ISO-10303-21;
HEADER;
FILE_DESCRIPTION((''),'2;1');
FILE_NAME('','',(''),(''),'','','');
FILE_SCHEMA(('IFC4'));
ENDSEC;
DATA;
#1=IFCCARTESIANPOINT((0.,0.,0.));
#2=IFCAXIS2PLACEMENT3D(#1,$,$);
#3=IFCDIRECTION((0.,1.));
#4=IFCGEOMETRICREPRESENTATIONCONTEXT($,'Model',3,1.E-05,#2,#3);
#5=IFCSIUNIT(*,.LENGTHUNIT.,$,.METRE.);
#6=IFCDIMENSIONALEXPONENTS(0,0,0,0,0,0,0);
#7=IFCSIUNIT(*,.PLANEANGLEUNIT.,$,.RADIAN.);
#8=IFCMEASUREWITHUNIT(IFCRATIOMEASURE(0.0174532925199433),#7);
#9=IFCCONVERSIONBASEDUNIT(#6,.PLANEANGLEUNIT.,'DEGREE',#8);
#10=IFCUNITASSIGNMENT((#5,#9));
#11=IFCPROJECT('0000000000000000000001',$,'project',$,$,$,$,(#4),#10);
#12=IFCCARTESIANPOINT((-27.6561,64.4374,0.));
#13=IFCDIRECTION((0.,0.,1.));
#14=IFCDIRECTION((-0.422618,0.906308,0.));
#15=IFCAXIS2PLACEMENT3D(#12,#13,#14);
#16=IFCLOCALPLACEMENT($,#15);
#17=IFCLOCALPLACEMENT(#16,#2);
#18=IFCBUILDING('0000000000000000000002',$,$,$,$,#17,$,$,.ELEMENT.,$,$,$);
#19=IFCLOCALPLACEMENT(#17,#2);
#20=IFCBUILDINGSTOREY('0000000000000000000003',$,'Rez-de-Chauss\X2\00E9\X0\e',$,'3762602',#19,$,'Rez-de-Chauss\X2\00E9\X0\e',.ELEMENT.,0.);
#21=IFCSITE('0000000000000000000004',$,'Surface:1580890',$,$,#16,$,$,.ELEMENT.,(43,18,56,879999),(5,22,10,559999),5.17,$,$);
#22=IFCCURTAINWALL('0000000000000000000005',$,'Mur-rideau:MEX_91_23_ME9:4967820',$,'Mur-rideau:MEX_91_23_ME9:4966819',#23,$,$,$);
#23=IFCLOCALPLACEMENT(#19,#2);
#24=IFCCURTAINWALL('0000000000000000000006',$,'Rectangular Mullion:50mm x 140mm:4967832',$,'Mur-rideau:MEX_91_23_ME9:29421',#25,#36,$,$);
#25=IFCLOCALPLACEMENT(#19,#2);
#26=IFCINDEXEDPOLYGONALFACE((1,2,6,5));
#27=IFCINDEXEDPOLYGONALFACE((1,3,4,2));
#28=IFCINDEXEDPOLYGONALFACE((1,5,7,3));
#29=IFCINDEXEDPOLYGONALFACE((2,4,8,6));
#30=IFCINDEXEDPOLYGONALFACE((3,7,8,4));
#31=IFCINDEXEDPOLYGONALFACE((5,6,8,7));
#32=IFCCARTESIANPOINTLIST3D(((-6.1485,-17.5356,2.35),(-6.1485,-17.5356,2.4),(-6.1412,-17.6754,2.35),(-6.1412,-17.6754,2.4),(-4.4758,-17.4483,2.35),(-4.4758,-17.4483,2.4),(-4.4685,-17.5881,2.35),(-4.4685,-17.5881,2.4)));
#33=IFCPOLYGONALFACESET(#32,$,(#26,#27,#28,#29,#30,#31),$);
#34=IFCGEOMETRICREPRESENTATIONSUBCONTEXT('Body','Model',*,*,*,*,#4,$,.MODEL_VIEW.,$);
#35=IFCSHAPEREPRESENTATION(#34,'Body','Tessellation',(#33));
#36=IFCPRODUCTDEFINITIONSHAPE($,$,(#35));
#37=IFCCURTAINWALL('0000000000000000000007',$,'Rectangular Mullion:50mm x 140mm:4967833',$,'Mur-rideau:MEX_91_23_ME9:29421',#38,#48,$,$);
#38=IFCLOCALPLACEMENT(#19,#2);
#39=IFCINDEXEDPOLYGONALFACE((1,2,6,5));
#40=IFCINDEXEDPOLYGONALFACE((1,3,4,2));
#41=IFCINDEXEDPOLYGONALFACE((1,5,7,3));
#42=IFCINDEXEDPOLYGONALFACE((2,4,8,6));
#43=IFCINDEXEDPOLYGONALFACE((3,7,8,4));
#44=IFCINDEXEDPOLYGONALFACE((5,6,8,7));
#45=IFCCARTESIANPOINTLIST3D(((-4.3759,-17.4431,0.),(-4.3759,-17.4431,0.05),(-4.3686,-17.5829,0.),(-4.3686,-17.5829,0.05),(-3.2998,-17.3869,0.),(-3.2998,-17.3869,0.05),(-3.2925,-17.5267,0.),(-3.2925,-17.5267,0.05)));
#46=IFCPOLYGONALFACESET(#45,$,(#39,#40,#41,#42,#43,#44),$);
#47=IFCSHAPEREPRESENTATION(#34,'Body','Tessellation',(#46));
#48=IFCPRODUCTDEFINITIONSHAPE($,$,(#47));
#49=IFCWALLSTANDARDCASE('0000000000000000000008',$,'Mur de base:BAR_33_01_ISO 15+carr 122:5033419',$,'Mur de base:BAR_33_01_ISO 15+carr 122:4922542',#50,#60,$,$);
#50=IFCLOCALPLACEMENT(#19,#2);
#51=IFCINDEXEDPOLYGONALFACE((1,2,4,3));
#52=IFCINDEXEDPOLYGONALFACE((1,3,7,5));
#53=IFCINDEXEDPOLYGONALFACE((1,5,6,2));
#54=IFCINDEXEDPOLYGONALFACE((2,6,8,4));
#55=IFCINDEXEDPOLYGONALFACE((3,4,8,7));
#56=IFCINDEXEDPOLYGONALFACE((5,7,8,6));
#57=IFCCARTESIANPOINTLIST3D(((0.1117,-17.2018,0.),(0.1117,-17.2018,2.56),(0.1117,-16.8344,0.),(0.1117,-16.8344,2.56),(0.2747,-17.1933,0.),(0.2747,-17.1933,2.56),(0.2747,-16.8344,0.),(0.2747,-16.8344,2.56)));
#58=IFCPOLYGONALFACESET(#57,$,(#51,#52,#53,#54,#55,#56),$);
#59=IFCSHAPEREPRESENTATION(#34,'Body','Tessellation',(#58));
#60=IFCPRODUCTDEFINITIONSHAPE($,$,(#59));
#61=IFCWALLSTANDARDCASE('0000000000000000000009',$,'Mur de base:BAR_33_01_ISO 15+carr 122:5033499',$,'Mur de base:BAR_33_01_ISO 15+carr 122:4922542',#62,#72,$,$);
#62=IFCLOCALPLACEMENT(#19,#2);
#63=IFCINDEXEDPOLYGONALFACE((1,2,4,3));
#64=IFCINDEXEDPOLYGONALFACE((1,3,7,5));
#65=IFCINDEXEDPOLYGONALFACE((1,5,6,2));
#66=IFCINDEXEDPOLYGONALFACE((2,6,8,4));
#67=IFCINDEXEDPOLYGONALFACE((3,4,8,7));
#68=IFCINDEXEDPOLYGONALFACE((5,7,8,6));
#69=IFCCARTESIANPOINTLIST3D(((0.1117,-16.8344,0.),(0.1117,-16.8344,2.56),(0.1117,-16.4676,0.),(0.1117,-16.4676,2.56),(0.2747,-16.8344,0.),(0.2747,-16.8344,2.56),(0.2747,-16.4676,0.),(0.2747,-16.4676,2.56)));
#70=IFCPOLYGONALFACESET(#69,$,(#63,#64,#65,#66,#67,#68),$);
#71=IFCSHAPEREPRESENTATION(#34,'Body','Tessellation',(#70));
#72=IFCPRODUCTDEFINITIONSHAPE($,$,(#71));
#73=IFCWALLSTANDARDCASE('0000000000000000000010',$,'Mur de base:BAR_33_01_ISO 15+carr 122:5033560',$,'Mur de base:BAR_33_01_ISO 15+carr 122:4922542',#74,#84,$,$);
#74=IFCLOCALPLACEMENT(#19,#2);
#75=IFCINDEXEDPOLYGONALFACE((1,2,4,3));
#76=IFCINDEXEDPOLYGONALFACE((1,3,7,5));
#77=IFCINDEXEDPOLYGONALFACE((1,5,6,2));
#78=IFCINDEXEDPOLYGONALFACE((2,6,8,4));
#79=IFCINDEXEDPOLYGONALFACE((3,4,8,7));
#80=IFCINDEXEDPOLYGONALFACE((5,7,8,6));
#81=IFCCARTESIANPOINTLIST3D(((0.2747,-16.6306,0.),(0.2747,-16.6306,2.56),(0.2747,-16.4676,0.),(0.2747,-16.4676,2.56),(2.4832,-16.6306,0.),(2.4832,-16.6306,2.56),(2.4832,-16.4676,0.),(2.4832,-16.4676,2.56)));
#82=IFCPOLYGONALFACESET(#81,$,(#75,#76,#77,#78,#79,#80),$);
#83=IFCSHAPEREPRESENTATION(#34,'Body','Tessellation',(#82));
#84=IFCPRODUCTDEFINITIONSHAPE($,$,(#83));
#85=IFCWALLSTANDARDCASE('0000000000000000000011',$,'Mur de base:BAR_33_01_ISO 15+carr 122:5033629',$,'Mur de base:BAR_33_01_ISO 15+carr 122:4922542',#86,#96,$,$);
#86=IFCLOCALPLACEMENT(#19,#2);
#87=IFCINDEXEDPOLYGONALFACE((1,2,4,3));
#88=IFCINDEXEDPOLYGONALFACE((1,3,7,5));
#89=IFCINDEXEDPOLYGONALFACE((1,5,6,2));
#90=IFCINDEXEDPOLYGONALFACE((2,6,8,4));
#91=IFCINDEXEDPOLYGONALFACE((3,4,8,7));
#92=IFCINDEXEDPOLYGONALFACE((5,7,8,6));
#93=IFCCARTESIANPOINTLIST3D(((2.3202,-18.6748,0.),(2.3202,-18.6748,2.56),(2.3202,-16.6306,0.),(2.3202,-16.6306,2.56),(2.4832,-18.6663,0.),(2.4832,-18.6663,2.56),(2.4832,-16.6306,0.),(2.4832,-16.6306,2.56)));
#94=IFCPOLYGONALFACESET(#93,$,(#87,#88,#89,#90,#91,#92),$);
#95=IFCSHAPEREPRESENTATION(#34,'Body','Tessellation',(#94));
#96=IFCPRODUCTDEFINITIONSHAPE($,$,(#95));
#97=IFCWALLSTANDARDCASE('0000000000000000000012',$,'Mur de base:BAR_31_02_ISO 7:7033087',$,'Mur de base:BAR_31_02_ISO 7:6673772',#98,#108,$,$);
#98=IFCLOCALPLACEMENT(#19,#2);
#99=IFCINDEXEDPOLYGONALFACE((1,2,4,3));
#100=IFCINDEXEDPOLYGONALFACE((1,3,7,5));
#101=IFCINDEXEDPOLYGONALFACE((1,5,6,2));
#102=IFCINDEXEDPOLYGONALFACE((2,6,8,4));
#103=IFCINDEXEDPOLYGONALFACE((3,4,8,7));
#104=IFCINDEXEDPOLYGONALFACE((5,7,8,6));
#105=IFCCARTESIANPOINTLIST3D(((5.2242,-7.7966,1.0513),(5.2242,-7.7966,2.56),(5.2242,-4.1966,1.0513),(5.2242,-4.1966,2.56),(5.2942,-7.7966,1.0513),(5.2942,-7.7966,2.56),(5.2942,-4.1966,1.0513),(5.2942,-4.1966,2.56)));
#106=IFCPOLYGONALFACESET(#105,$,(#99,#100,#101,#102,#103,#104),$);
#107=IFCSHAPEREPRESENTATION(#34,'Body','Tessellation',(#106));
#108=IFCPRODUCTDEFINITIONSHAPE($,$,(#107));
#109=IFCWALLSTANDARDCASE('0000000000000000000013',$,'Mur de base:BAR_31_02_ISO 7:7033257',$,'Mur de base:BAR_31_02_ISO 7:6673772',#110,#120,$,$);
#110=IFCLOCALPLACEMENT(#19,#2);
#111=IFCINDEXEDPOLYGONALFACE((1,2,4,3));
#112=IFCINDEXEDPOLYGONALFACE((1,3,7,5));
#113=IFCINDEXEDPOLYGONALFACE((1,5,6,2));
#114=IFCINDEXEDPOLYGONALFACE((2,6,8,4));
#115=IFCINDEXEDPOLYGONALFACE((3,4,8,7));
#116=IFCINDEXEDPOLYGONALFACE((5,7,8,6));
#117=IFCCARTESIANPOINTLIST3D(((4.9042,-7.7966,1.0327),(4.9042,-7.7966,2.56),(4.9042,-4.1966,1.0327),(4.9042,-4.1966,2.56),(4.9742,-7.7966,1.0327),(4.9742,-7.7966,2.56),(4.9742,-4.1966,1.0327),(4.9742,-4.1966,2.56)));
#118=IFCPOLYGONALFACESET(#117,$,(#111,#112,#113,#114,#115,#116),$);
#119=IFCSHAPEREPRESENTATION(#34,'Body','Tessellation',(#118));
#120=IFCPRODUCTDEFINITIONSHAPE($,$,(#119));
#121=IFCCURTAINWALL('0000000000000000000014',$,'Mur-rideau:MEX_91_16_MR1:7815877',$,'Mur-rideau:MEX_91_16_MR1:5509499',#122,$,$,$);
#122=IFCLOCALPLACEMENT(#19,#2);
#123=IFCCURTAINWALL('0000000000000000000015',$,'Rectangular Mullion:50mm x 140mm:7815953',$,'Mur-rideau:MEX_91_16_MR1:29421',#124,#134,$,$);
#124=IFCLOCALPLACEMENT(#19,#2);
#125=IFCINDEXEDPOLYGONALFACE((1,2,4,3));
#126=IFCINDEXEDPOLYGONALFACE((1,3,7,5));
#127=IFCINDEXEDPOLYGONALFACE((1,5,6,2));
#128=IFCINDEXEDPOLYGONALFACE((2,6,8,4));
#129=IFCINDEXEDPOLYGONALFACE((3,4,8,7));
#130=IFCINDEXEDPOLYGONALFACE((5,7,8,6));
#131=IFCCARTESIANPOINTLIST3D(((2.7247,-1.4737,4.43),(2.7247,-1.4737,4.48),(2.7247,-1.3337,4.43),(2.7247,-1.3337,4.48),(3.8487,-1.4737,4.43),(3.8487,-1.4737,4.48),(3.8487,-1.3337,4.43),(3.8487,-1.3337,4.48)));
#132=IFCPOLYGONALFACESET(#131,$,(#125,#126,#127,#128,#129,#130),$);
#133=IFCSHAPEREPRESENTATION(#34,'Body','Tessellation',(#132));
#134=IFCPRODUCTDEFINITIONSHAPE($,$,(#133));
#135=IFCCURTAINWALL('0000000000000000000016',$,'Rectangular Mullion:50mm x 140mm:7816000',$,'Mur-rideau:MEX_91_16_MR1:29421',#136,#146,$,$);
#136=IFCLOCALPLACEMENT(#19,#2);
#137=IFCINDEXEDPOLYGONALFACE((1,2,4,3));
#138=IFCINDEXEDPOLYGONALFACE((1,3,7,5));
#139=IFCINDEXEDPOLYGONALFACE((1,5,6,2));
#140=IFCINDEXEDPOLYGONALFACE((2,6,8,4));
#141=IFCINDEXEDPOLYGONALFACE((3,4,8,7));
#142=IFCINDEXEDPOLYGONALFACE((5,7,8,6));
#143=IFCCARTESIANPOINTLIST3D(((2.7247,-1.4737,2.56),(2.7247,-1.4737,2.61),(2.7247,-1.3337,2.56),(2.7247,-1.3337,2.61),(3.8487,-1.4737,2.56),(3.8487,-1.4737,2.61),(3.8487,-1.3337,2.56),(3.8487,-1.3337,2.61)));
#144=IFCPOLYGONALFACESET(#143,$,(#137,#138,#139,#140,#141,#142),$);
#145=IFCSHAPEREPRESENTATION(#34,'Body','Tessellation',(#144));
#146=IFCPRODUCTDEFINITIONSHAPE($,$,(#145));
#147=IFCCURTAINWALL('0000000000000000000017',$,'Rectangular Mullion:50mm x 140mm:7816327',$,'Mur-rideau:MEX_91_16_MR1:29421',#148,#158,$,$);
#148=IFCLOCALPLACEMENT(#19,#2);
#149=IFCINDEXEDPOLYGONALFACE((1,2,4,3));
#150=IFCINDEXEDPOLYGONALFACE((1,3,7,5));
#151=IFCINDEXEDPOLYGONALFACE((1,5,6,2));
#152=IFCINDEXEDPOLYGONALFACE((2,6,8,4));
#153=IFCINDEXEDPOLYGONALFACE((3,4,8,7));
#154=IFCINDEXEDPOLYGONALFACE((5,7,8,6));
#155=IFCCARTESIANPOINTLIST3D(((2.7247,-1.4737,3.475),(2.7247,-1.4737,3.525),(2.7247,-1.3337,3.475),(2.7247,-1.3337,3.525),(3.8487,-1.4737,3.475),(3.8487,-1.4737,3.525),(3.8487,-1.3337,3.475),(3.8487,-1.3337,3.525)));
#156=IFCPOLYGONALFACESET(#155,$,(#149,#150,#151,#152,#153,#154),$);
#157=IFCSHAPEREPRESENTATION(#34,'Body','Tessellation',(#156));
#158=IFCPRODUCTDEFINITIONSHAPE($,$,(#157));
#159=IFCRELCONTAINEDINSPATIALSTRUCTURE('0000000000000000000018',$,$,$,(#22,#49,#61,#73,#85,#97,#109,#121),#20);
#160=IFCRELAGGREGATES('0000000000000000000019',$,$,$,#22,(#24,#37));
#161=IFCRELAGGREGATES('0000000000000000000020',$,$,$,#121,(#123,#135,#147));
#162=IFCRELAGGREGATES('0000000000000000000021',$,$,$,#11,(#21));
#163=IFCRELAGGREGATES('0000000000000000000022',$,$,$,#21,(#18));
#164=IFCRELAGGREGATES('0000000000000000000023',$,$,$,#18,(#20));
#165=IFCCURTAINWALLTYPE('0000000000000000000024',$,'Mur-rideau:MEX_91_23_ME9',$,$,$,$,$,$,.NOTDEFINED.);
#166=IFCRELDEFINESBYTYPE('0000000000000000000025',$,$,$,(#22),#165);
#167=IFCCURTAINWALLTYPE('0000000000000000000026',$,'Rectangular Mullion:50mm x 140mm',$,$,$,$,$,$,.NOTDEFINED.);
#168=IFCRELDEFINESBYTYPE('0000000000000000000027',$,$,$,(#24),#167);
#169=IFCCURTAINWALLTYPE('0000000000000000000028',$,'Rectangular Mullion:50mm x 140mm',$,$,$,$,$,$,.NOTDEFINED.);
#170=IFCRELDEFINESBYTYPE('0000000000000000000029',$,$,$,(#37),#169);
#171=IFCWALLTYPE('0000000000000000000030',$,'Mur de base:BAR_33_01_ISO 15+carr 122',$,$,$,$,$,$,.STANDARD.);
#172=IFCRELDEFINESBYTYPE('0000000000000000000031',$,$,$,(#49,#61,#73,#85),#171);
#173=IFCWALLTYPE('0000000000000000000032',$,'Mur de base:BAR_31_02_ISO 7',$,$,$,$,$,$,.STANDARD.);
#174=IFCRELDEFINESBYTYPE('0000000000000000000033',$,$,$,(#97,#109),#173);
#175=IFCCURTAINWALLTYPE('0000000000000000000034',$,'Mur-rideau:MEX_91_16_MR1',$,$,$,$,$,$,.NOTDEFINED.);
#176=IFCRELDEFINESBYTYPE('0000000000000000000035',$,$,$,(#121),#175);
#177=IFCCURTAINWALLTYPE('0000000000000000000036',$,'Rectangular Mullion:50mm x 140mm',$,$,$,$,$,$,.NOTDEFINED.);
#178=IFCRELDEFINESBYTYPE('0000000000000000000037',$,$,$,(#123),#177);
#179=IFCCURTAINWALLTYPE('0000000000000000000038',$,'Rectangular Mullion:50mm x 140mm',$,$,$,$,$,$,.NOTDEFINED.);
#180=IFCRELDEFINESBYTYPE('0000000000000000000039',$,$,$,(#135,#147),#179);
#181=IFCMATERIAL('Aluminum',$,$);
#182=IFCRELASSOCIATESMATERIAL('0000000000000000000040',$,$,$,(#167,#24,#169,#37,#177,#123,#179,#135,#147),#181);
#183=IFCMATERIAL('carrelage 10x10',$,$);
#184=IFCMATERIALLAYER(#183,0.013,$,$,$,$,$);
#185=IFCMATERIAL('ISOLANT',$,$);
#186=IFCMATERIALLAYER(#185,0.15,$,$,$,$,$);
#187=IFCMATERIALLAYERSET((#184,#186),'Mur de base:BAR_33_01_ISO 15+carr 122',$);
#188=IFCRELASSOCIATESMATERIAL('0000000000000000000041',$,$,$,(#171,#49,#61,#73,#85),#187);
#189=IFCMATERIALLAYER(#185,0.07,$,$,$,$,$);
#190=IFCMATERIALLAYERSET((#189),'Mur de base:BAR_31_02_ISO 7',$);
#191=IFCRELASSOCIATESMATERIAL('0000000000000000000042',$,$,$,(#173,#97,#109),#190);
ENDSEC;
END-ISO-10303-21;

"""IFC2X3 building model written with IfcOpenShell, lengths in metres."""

from ifc_helpers import new_model, entity, si_unit, converted_unit, direction, frame, frame_2d, origin, origin_2d_with_axis, place, context, subcontext, project, spatial, polyline, rectangle, outline, extrude, clip, halfspace, source, transform, mapped, material, layer, layer_set, layer_usage, type_object, type_shapes, element, aggregate, save


model = new_model("IFC2X3")

# Units and contexts
model_context = context("Model", 3, precision=1e-05, world=origin(), true_north=direction((0.0, 1.0)))
body_context = subcontext(model_context, "Body", "Model", "MODEL_VIEW")
ifc_project = project(units=[si_unit("LENGTHUNIT", "METRE"), converted_unit("PLANEANGLEUNIT", "DEGREE", entity("IfcRatioMeasure", 0.0174532925199433), si_unit("PLANEANGLEUNIT", "RADIAN"), dimensions=[0, 0, 0, 0, 0, 0, 0])], contexts=[model_context])

# Site, building, storey
site_placement = place(None, frame((-27.6561, 64.4374, 0.0), z_axis=(0.0, 0.0, 1.0), x_axis=(-0.422618, 0.906308, 0.0)))
site = spatial("IfcSite", under=ifc_project, at=site_placement, Name="Surface:1580890", CompositionType="ELEMENT", RefLatitude=(43, 18, 56, 879999), RefLongitude=(5, 22, 10, 559999), RefElevation=5.17)
building_placement = place(site_placement, origin())
building = spatial("IfcBuilding", under=site, at=building_placement, CompositionType="ELEMENT")
storey_placement = place(building_placement, origin())
storey = spatial("IfcBuildingStorey", under=building, at=storey_placement, Name="Rez-de-Chaussée", ObjectType="3762602", LongName="Rez-de-Chaussée", CompositionType="ELEMENT", Elevation=0.0)

# Shared definitions
ifc_material_1 = material(Name="ISOLANT")

# Curtain walls
curtain_wall_type_1 = type_object("IfcCurtainWallType", Name="Mur-rideau:MEX_91_23_ME9", PredefinedType="NOTDEFINED")
curtain_wall_1_placement = place(storey_placement, origin())
curtain_wall_1 = element("IfcCurtainWall", 1, at=curtain_wall_1_placement, inside=storey, type_object=curtain_wall_type_1, Name="Mur-rideau:MEX_91_23_ME9:4967820", ObjectType="Mur-rideau:MEX_91_23_ME9:4966819")
ifc_material_2 = material(Name="Aluminum")
curtain_wall_type_2 = type_object("IfcCurtainWallType", Name="Rectangular Mullion:50mm x 140mm", PredefinedType="NOTDEFINED", material=ifc_material_2)
shared_shape_1 = source(origin(), body_context, "Body", "SweptSolid", [
    extrude(rectangle(XDim=0.05, YDim=0.14, at=origin_2d_with_axis()), frame((-0.025, 0.0, -1.675), z_axis=(0.0, 0.0, 1.0), x_axis=(-1.0, 0.0, 0.0)), (0.0, 0.0, 1.0), 1.675),
])
type_shapes(curtain_wall_type_2, [shared_shape_1])
curtain_wall_2_placement = place(storey_placement, frame((-4.4722, -17.5182, 2.4), z_axis=(0.998641, 0.052122, 0.0), x_axis=(0.0, 0.0, 1.0)))
curtain_wall_2 = element("IfcCurtainWall", 2, at=curtain_wall_2_placement, type_object=curtain_wall_type_2, material=ifc_material_2, Name="Rectangular Mullion:50mm x 140mm:4967832", ObjectType="Mur-rideau:MEX_91_23_ME9:29421", context=body_context, shape_type="MappedRepresentation", body=[
    mapped(shared_shape_1, transform((0.0, 0.0, 0.0), scale=1.0)),
])
curtain_wall_type_3 = type_object("IfcCurtainWallType", Name="Rectangular Mullion:50mm x 140mm", PredefinedType="NOTDEFINED", material=ifc_material_2)
shared_shape_2 = source(origin(), body_context, "Body", "SweptSolid", [
    extrude(rectangle(XDim=0.05, YDim=0.14, at=origin_2d_with_axis()), frame((-0.025, 0.0, -1.0776), z_axis=(0.0, 0.0, 1.0), x_axis=(-1.0, 0.0, 0.0)), (0.0, 0.0, 1.0), 1.0776),
])
type_shapes(curtain_wall_type_3, [shared_shape_2])
curtain_wall_3_placement = place(storey_placement, frame((-4.3723, -17.513, 0.0), z_axis=(-0.998641, -0.052122, 0.0), x_axis=(0.0, 0.0, -1.0)))
curtain_wall_3 = element("IfcCurtainWall", 3, at=curtain_wall_3_placement, type_object=curtain_wall_type_3, material=ifc_material_2, Name="Rectangular Mullion:50mm x 140mm:4967833", ObjectType="Mur-rideau:MEX_91_23_ME9:29421", context=body_context, shape_type="MappedRepresentation", body=[
    mapped(shared_shape_2, transform((0.0, 0.0, 0.0), scale=1.0)),
])
aggregate(curtain_wall_1, [curtain_wall_2, curtain_wall_3])

# Walls
ifc_material_3 = material(Name="carrelage 10x10")
ifc_layer_1 = layer(ifc_material_3, 0.013)
ifc_layer_2 = layer(ifc_material_1, 0.15)
ifc_layer_set_1 = layer_set([ifc_layer_1, ifc_layer_2], Name="Mur de base:BAR_33_01_ISO 15+carr 122")
ifc_layer_usage_1 = layer_usage(ifc_layer_set_1, "AXIS2", "NEGATIVE", 0.0815)
wall_type_1 = type_object("IfcWallType", Name="Mur de base:BAR_33_01_ISO 15+carr 122", PredefinedType="STANDARD", material=ifc_layer_set_1)
wall_1_placement = place(storey_placement, frame((0.1932, -17.2018, 0.0), z_axis=(0.0, 0.0, 1.0), x_axis=(0.0, 1.0, 0.0)))
element("IfcWallStandardCase", 4, at=wall_1_placement, inside=storey, type_object=wall_type_1, material=ifc_layer_usage_1, Name="Mur de base:BAR_33_01_ISO 15+carr 122:5033419", ObjectType="Mur de base:BAR_33_01_ISO 15+carr 122:4922542", context=body_context, shape_type="Clipping", body=[
    clip(extrude(outline(polyline([(0.3674, -0.0815), (0.3674, 0.0815), (0.0, 0.0815), (0.0085, -0.0815), (0.3674, -0.0815)])), origin(), (0.0, 0.0, 1.0), 2.56), halfspace(origin(), True)),
])
ifc_layer_usage_2 = layer_usage(ifc_layer_set_1, "AXIS2", "NEGATIVE", 0.0815)
wall_2_placement = place(storey_placement, frame((0.1932, -16.8344, 0.0), z_axis=(0.0, 0.0, 1.0), x_axis=(0.0, 1.0, 0.0)))
element("IfcWallStandardCase", 5, at=wall_2_placement, inside=storey, type_object=wall_type_1, material=ifc_layer_usage_2, Name="Mur de base:BAR_33_01_ISO 15+carr 122:5033499", ObjectType="Mur de base:BAR_33_01_ISO 15+carr 122:4922542", context=body_context, shape_type="Clipping", body=[
    clip(extrude(rectangle(XDim=0.3669, YDim=0.163, at=frame_2d((0.1834, 0.0), x_axis=(-1.0, 0.0))), origin(), (0.0, 0.0, 1.0), 2.56), halfspace(origin(), True)),
])
ifc_layer_usage_3 = layer_usage(ifc_layer_set_1, "AXIS2", "NEGATIVE", 0.0815)
wall_3_placement = place(storey_placement, frame((0.2747, -16.5491, 0.0)))
element("IfcWallStandardCase", 6, at=wall_3_placement, inside=storey, type_object=wall_type_1, material=ifc_layer_usage_3, Name="Mur de base:BAR_33_01_ISO 15+carr 122:5033560", ObjectType="Mur de base:BAR_33_01_ISO 15+carr 122:4922542", context=body_context, shape_type="Clipping", body=[
    clip(extrude(rectangle(XDim=2.2084, YDim=0.163, at=frame_2d((1.1042, 0.0), x_axis=(-1.0, 0.0))), origin(), (0.0, 0.0, 1.0), 2.56), halfspace(origin(), True)),
])
ifc_layer_usage_4 = layer_usage(ifc_layer_set_1, "AXIS2", "NEGATIVE", 0.0815)
wall_4_placement = place(storey_placement, frame((2.4017, -16.6306, 0.0), z_axis=(0.0, 0.0, 1.0), x_axis=(0.0, -1.0, 0.0)))
element("IfcWallStandardCase", 7, at=wall_4_placement, inside=storey, type_object=wall_type_1, material=ifc_layer_usage_4, Name="Mur de base:BAR_33_01_ISO 15+carr 122:5033629", ObjectType="Mur de base:BAR_33_01_ISO 15+carr 122:4922542", context=body_context, shape_type="Clipping", body=[
    clip(extrude(outline(polyline([(2.0442, -0.0815), (2.0357, 0.0815), (1.8725, 0.0815), (0.0, 0.0815), (0.0, -0.0815), (2.0442, -0.0815)])), origin(), (0.0, 0.0, 1.0), 2.56), halfspace(origin(), True)),
])
ifc_layer_3 = layer(ifc_material_1, 0.07)
ifc_layer_set_2 = layer_set([ifc_layer_3], Name="Mur de base:BAR_31_02_ISO 7")
ifc_layer_usage_5 = layer_usage(ifc_layer_set_2, "AXIS2", "NEGATIVE", 0.035)
wall_type_2 = type_object("IfcWallType", Name="Mur de base:BAR_31_02_ISO 7", PredefinedType="STANDARD", material=ifc_layer_set_2)
wall_5_placement = place(storey_placement, frame((5.2592, -4.1966, 1.0513), z_axis=(0.0, 0.0, 1.0), x_axis=(0.0, -1.0, 0.0)))
element("IfcWallStandardCase", 8, at=wall_5_placement, inside=storey, type_object=wall_type_2, material=ifc_layer_usage_5, Name="Mur de base:BAR_31_02_ISO 7:7033087", ObjectType="Mur de base:BAR_31_02_ISO 7:6673772", context=body_context, shape_type="Clipping", body=[
    clip(extrude(rectangle(XDim=3.6, YDim=0.07, at=frame_2d((1.8, 0.0), x_axis=(-1.0, 0.0))), origin(), (0.0, 0.0, 1.0), 1.5087), halfspace(origin(), True)),
])
ifc_layer_usage_6 = layer_usage(ifc_layer_set_2, "AXIS2", "POSITIVE", -0.035)
wall_6_placement = place(storey_placement, frame((4.9392, -4.1966, 1.0327), z_axis=(0.0, 0.0, 1.0), x_axis=(0.0, -1.0, 0.0)))
element("IfcWallStandardCase", 9, at=wall_6_placement, inside=storey, type_object=wall_type_2, material=ifc_layer_usage_6, Name="Mur de base:BAR_31_02_ISO 7:7033257", ObjectType="Mur de base:BAR_31_02_ISO 7:6673772", context=body_context, shape_type="Clipping", body=[
    clip(extrude(rectangle(XDim=3.6, YDim=0.07, at=frame_2d((1.8, 0.0), x_axis=(-1.0, 0.0))), origin(), (0.0, 0.0, 1.0), 1.5273), halfspace(origin(), True)),
])

# Curtain walls
curtain_wall_type_4 = type_object("IfcCurtainWallType", Name="Mur-rideau:MEX_91_16_MR1", PredefinedType="NOTDEFINED")
curtain_wall_4_placement = place(storey_placement, origin())
curtain_wall_4 = element("IfcCurtainWall", 10, at=curtain_wall_4_placement, inside=storey, type_object=curtain_wall_type_4, Name="Mur-rideau:MEX_91_16_MR1:7815877", ObjectType="Mur-rideau:MEX_91_16_MR1:5509499")
curtain_wall_type_5 = type_object("IfcCurtainWallType", Name="Rectangular Mullion:50mm x 140mm", PredefinedType="NOTDEFINED", material=ifc_material_2)
shared_shape_3 = source(origin(), body_context, "Body", "SweptSolid", [
    extrude(rectangle(XDim=0.05, YDim=0.14, at=origin_2d_with_axis()), frame((-0.025, 0.0, -1.124), z_axis=(0.0, 0.0, 1.0), x_axis=(-1.0, 0.0, 0.0)), (0.0, 0.0, 1.0), 1.124),
])
type_shapes(curtain_wall_type_5, [shared_shape_3])
curtain_wall_5_placement = place(storey_placement, frame((2.7247, -1.4037, 4.48), z_axis=(-1.0, 0.0, 0.0), x_axis=(0.0, 0.0, 1.0)))
curtain_wall_5 = element("IfcCurtainWall", 11, at=curtain_wall_5_placement, type_object=curtain_wall_type_5, material=ifc_material_2, Name="Rectangular Mullion:50mm x 140mm:7815953", ObjectType="Mur-rideau:MEX_91_16_MR1:29421", context=body_context, shape_type="MappedRepresentation", body=[
    mapped(shared_shape_3, transform((0.0, 0.0, 0.0), scale=1.0)),
])
curtain_wall_type_6 = type_object("IfcCurtainWallType", Name="Rectangular Mullion:50mm x 140mm", PredefinedType="NOTDEFINED", material=ifc_material_2)
shared_shape_4 = source(origin(), body_context, "Body", "SweptSolid", [
    extrude(rectangle(XDim=0.05, YDim=0.14, at=origin_2d_with_axis()), frame((0.0, 0.0, -1.124), z_axis=(0.0, 0.0, 1.0), x_axis=(-1.0, 0.0, 0.0)), (0.0, 0.0, 1.0), 1.124),
])
type_shapes(curtain_wall_type_6, [shared_shape_4])
curtain_wall_6_placement = place(storey_placement, frame((2.7247, -1.4037, 2.585), z_axis=(-1.0, 0.0, 0.0), x_axis=(0.0, 0.0, 1.0)))
curtain_wall_6 = element("IfcCurtainWall", 12, at=curtain_wall_6_placement, type_object=curtain_wall_type_6, material=ifc_material_2, Name="Rectangular Mullion:50mm x 140mm:7816000", ObjectType="Mur-rideau:MEX_91_16_MR1:29421", context=body_context, shape_type="MappedRepresentation", body=[
    mapped(shared_shape_4, transform((0.0, 0.0, 0.0), scale=1.0)),
])
curtain_wall_7_placement = place(storey_placement, frame((2.7247, -1.4037, 3.5), z_axis=(-1.0, 0.0, 0.0), x_axis=(0.0, 0.0, 1.0)))
curtain_wall_7 = element("IfcCurtainWall", 13, at=curtain_wall_7_placement, type_object=curtain_wall_type_6, material=ifc_material_2, Name="Rectangular Mullion:50mm x 140mm:7816327", ObjectType="Mur-rideau:MEX_91_16_MR1:29421", context=body_context, shape_type="MappedRepresentation", body=[
    mapped(shared_shape_4, transform((0.0, 0.0, 0.0), scale=1.0)),
])
aggregate(curtain_wall_4, [curtain_wall_5, curtain_wall_6, curtain_wall_7])

save(model, "model.ifc")
